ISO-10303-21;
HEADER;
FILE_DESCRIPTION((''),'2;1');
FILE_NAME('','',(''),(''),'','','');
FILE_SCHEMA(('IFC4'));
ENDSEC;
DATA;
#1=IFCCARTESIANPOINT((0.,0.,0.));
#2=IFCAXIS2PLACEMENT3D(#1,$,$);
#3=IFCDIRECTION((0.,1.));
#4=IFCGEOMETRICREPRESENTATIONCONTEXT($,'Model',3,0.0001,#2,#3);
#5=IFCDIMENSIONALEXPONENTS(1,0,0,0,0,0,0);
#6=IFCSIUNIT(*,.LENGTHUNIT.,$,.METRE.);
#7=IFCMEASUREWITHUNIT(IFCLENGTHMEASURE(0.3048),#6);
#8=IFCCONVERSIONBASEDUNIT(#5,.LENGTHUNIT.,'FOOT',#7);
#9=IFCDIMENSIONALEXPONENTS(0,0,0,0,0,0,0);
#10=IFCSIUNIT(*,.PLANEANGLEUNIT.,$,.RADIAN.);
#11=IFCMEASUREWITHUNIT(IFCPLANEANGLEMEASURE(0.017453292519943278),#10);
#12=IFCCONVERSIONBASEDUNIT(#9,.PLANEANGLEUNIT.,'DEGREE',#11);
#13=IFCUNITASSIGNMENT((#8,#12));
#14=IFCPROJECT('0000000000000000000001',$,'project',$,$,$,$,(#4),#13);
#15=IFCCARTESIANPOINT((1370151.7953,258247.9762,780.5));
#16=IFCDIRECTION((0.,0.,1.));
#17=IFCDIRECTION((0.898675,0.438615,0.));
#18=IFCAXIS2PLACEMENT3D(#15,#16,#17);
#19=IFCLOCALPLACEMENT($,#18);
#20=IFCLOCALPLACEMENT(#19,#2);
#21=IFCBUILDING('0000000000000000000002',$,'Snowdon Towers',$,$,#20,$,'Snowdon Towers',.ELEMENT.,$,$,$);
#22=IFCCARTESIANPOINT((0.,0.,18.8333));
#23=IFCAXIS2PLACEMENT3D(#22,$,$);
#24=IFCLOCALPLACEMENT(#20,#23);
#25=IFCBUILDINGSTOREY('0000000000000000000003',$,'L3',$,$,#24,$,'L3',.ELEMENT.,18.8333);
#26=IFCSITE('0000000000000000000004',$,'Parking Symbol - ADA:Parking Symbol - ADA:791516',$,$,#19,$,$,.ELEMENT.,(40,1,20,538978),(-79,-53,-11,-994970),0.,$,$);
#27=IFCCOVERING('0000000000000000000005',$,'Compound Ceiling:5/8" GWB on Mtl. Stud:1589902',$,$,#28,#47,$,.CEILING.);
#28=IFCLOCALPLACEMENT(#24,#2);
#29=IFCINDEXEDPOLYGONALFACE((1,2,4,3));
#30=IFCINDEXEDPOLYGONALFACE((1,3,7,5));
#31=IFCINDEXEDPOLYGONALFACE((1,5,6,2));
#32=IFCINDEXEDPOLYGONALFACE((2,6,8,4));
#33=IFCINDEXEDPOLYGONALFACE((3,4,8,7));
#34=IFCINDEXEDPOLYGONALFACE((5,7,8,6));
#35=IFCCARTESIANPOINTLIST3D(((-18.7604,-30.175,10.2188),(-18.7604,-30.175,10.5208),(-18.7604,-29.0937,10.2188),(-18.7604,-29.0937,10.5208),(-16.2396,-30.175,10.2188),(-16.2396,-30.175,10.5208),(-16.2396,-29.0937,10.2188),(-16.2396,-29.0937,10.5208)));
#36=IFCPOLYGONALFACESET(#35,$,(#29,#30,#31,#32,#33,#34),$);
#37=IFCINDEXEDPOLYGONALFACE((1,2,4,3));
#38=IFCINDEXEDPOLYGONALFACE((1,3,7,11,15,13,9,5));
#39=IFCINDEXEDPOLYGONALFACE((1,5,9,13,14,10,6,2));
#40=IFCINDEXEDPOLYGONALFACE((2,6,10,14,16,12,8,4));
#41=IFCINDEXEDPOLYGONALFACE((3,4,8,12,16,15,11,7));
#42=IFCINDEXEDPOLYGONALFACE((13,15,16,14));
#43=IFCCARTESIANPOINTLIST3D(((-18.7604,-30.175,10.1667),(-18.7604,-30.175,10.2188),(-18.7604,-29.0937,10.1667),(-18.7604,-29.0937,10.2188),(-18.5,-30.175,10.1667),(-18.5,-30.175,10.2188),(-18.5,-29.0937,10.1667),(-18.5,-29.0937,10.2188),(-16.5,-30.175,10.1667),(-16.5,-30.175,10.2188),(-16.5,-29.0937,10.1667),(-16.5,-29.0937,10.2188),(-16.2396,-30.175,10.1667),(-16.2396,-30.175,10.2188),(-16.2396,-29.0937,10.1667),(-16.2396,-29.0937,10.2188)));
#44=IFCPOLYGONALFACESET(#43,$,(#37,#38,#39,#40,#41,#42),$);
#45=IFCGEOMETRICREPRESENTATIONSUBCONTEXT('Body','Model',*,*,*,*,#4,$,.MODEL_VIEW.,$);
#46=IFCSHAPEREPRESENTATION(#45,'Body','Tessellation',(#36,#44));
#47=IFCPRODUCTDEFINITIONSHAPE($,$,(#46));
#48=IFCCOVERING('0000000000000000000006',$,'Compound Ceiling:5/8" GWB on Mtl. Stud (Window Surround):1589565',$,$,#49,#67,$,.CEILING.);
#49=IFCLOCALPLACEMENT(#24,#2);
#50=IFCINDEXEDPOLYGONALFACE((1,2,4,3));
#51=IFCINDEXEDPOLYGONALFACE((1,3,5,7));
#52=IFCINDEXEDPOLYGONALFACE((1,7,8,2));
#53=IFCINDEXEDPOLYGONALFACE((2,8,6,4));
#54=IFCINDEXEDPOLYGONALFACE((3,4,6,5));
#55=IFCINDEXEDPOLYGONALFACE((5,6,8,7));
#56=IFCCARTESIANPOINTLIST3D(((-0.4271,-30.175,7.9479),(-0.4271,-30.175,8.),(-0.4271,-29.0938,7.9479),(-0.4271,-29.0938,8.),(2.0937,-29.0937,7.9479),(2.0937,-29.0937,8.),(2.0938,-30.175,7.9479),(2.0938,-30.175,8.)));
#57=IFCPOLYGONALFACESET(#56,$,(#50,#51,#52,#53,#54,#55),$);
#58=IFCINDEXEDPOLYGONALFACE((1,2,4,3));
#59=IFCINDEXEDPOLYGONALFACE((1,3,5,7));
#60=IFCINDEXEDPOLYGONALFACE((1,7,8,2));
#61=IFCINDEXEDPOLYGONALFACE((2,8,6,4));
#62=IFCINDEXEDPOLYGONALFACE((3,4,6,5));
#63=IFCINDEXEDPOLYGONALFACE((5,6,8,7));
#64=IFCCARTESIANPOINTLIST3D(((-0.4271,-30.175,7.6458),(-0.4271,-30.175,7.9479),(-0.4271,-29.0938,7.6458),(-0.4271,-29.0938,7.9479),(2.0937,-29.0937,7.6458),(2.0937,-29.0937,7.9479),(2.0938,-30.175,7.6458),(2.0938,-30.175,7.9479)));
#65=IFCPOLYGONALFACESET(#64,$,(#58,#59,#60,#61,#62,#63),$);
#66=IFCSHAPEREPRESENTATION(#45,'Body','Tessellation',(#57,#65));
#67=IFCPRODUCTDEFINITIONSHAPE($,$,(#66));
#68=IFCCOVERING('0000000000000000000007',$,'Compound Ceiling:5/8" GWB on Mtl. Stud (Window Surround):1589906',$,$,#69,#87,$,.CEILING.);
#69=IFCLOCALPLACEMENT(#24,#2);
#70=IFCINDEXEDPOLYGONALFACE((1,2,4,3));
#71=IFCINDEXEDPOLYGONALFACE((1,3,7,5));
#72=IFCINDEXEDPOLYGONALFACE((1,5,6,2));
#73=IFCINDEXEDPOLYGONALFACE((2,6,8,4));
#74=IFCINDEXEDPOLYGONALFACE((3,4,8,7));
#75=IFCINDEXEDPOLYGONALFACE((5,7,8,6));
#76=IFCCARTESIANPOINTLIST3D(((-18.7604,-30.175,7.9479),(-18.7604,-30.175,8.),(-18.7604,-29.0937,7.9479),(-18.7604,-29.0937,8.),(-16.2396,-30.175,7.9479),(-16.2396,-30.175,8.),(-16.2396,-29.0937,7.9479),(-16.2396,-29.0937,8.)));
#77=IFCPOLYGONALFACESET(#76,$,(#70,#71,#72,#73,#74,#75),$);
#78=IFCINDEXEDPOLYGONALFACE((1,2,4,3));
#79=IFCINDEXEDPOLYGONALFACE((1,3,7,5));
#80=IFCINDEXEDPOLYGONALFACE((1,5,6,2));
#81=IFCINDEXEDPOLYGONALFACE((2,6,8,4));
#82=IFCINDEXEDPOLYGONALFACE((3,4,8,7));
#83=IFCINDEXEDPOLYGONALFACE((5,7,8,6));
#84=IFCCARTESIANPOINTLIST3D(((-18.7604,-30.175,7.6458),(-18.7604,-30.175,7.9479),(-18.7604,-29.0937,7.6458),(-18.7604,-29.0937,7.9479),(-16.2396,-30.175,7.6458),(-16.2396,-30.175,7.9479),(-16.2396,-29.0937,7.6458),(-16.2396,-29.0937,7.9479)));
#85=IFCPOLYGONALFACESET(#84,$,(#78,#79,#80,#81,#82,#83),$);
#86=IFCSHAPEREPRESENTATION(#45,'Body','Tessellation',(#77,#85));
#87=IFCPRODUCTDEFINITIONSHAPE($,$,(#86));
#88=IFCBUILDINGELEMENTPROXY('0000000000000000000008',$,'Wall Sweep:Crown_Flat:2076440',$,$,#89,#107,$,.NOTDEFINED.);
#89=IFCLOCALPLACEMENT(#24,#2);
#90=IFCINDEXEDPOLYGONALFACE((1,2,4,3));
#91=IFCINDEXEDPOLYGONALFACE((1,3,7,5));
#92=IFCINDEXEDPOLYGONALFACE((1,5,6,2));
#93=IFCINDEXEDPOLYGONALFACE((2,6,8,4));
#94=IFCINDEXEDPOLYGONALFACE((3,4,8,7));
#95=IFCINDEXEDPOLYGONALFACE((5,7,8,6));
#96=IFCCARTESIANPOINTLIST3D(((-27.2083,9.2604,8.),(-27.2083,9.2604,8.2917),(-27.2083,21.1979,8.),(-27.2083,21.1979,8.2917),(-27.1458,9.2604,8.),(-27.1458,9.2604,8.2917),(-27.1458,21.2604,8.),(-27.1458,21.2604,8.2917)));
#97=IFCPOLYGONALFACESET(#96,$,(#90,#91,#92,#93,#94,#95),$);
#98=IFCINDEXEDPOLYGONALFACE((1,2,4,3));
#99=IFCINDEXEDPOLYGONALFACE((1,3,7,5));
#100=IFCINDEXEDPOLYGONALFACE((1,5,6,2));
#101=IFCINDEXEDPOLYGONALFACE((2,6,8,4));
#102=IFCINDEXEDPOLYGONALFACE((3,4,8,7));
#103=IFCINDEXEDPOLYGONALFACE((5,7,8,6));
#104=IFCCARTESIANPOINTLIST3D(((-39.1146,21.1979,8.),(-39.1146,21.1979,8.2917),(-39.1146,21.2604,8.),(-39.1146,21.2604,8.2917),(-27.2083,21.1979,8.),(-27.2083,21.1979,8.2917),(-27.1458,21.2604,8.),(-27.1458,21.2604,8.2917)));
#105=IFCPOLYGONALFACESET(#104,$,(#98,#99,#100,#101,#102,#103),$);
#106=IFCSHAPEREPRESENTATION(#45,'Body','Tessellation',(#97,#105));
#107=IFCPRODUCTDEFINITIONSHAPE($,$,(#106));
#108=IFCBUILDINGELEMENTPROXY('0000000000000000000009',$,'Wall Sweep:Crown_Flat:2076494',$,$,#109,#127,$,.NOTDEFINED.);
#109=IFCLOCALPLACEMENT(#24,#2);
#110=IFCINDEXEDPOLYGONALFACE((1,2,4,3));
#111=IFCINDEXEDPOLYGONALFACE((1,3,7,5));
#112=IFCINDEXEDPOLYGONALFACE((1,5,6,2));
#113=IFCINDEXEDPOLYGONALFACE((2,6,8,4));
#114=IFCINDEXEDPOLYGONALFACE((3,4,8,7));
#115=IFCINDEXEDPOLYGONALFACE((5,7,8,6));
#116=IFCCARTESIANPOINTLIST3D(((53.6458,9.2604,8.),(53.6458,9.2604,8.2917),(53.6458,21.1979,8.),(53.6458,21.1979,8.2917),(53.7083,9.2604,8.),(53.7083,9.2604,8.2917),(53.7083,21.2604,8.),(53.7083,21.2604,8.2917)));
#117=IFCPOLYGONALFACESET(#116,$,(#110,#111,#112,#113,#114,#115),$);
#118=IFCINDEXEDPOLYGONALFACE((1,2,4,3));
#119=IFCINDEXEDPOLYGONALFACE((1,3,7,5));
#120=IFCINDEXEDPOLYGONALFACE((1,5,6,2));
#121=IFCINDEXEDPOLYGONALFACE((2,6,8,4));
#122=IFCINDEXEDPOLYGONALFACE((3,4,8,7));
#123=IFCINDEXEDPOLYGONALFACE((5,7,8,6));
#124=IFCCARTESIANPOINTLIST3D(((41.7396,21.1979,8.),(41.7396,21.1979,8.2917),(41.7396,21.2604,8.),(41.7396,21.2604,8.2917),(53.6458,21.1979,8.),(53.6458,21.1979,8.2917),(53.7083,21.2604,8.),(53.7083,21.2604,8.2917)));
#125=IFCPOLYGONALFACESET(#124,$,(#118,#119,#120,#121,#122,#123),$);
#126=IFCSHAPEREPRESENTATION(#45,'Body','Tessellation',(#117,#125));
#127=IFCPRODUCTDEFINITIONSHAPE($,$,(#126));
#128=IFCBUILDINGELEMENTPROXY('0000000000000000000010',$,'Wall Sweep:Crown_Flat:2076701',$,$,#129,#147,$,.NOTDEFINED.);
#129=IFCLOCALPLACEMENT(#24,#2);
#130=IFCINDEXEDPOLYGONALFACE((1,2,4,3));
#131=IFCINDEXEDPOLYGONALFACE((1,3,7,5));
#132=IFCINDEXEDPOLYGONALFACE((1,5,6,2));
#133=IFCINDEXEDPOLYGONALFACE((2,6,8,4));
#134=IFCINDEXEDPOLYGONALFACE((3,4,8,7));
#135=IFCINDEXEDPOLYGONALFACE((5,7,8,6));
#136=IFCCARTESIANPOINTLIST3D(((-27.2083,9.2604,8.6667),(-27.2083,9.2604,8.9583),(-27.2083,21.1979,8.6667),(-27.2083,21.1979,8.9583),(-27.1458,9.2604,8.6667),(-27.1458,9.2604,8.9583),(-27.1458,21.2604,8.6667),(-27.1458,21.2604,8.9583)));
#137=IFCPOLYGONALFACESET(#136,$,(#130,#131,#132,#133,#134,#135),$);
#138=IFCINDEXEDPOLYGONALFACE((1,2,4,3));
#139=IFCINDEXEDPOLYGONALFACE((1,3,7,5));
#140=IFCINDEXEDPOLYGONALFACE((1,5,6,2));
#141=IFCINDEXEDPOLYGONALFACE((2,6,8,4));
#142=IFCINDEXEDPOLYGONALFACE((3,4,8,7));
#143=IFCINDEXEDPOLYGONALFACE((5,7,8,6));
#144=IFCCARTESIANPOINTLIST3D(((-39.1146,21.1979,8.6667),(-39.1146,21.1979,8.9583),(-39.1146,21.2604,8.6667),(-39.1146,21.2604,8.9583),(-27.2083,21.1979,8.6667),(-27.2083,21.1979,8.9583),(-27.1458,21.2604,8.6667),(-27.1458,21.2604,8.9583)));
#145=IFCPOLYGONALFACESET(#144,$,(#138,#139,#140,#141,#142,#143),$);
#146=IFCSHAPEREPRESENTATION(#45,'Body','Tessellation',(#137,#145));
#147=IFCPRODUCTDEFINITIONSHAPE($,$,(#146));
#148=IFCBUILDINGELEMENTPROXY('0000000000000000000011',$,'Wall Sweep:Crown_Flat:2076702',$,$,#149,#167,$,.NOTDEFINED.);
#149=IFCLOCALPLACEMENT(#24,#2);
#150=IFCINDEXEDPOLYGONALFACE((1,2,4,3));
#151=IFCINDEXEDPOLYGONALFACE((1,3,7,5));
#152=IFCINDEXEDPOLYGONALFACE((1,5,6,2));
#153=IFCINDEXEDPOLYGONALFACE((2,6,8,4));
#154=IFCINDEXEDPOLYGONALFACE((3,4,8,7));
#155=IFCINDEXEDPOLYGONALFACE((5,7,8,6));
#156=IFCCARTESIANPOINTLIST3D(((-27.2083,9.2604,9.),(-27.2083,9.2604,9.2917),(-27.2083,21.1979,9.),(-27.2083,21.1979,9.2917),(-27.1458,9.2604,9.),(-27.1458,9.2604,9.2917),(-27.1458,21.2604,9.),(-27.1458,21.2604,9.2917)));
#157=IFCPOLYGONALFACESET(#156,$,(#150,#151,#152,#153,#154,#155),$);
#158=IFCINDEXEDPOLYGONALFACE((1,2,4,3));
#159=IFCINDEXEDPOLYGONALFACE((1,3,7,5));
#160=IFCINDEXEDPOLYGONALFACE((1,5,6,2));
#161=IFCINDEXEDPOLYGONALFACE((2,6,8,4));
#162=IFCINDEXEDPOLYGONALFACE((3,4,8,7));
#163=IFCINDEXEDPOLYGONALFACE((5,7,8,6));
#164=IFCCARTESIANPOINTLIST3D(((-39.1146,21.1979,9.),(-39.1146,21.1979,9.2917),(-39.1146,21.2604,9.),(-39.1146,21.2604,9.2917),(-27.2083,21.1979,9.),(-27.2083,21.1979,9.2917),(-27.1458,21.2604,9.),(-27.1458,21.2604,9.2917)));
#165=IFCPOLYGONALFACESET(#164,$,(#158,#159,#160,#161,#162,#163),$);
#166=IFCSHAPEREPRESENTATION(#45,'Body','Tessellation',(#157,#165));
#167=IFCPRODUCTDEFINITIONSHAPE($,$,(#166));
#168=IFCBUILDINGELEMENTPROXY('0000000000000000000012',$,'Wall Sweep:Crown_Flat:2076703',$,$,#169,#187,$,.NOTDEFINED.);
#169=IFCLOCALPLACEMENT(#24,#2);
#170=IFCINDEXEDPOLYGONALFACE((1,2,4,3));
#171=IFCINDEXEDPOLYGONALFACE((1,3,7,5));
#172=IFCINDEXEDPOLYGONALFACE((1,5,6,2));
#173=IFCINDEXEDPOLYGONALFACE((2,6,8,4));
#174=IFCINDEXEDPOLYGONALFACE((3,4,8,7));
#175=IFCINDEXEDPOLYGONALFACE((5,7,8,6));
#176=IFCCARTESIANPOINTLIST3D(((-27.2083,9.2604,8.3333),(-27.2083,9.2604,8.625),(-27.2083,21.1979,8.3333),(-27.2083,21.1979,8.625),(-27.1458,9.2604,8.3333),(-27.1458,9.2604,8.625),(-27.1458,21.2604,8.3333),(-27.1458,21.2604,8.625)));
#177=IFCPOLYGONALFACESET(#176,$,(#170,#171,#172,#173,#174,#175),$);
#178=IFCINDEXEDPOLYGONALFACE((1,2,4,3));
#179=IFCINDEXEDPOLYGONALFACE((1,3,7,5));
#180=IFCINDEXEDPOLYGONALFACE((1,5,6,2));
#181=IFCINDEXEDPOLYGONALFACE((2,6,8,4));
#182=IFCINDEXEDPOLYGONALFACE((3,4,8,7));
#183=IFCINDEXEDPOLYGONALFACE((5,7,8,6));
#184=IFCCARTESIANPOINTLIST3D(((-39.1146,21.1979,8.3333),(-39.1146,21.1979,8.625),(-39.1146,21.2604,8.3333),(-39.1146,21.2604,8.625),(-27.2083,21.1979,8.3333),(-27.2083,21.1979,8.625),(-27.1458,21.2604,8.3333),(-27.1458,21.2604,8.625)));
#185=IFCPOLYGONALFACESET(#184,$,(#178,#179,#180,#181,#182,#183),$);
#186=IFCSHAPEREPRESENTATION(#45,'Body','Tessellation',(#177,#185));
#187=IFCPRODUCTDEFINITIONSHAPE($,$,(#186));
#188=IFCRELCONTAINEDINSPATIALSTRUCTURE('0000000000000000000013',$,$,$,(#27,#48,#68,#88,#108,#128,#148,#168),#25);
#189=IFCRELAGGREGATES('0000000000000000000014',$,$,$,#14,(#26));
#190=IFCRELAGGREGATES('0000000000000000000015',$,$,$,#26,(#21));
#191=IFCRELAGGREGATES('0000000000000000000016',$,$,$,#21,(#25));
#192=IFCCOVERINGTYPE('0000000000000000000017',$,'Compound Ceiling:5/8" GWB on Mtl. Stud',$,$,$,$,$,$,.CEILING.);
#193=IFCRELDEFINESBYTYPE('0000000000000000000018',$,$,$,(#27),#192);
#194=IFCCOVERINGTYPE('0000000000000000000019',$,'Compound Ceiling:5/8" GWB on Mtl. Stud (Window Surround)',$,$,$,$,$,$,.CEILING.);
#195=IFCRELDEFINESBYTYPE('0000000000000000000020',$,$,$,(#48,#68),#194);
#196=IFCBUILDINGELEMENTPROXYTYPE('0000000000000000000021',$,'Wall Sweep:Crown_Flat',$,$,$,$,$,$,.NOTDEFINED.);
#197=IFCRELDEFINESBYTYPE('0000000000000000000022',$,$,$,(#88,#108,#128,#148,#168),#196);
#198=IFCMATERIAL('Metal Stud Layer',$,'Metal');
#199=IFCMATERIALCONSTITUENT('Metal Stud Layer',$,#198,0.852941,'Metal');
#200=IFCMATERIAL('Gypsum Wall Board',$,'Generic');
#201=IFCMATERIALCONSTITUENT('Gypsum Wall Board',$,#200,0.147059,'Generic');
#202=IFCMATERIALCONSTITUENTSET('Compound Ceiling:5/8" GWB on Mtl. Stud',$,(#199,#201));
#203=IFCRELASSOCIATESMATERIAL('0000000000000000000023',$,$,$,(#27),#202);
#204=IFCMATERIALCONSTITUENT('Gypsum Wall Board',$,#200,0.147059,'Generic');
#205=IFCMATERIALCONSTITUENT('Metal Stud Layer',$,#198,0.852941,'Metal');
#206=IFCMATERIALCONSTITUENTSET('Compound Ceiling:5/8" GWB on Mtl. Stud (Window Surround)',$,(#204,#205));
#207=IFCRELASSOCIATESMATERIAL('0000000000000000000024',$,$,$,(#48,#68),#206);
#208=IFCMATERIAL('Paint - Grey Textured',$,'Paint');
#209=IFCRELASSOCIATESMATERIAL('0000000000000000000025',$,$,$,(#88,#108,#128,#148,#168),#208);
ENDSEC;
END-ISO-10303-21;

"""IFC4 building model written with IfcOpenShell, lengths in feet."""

from ifc_helpers import new_model, entity, si_unit, converted_unit, direction, frame, origin, place, context, subcontext, project, spatial, indexed_curve, outline, extrude, material, constituent, constituent_set, type_object, element, save


model = new_model("IFC4")

# Units and contexts
model_context = context("Model", 3, precision=0.0001, world=origin(), true_north=direction((0.0, 1.0)))
body_context = subcontext(model_context, "Body", "Model", "MODEL_VIEW")
ifc_project = project(units=[converted_unit("LENGTHUNIT", "FOOT", entity("IfcLengthMeasure", 0.3048), si_unit("LENGTHUNIT", "METRE"), dimensions=[1, 0, 0, 0, 0, 0, 0]), converted_unit("PLANEANGLEUNIT", "DEGREE", entity("IfcPlaneAngleMeasure", 0.017453292519943278), si_unit("PLANEANGLEUNIT", "RADIAN"), dimensions=[0, 0, 0, 0, 0, 0, 0])], contexts=[model_context])

# Site, building, storey
site_placement = place(None, frame((1370151.7953, 258247.9762, 780.5), z_axis=(0.0, 0.0, 1.0), x_axis=(0.898675, 0.438615, 0.0)))
site = spatial("IfcSite", under=ifc_project, at=site_placement, Name="Parking Symbol - ADA:Parking Symbol - ADA:791516", CompositionType="ELEMENT", RefLatitude=(40, 1, 20, 538978), RefLongitude=(-79, -53, -11, -994970), RefElevation=0.0)
building_placement = place(site_placement, origin())
building = spatial("IfcBuilding", under=site, at=building_placement, Name="Snowdon Towers", LongName="Snowdon Towers", CompositionType="ELEMENT")
storey_placement = place(building_placement, frame((0.0, 0.0, 18.8333)))
storey = spatial("IfcBuildingStorey", under=building, at=storey_placement, Name="L3", LongName="L3", CompositionType="ELEMENT", Elevation=18.8333)

# Shared definitions
ifc_material_1 = material(Name="Gypsum Wall Board", Category="Generic")

# Shared definitions
ifc_material_2 = material(Name="Metal Stud Layer", Category="Metal")

# Covering
ifc_constituent_1 = constituent(ifc_material_2, Name="Metal Stud Layer", Category="Metal", fraction=0.852941)
ifc_constituent_2 = constituent(ifc_material_1, Name="Gypsum Wall Board", Category="Generic", fraction=0.147059)
ifc_constituent_set_1 = constituent_set(constituents=[ifc_constituent_1, ifc_constituent_2], Name="Compound Ceiling:5/8\" GWB on Mtl. Stud")
covering_type_1 = type_object("IfcCoveringType", Name="Compound Ceiling:5/8\" GWB on Mtl. Stud", PredefinedType="CEILING")
covering_1_placement = place(storey_placement, origin())
element("IfcCovering", 1, at=covering_1_placement, inside=storey, type_object=covering_type_1, material=ifc_constituent_set_1, Name="Compound Ceiling:5/8\" GWB on Mtl. Stud:1589902", PredefinedType="CEILING", context=body_context, shape_type="SweptSolid", body=[
    extrude(outline(indexed_curve([(-0.5406, -1.2604), (0.5406, -1.2604), (0.5406, 1.2604), (-0.5406, 1.2604), (-0.5406, -1.2604)], self_intersect=False)), frame((-17.5, -29.6344, 10.2188), z_axis=(0.0, 0.0, 1.0), x_axis=(0.0, 1.0, 0.0)), (0.0, 0.0, 1.0), 0.3021),
    extrude(outline(indexed_curve([(-0.5406, -1.2604), (0.5406, -1.2604), (0.5406, -1.0), (0.5406, 1.0), (0.5406, 1.2604), (-0.5406, 1.2604), (-0.5406, 1.0), (-0.5406, -1.0), (-0.5406, -1.2604)], self_intersect=False)), frame((-17.5, -29.6344, 10.1667), z_axis=(0.0, 0.0, 1.0), x_axis=(0.0, -1.0, 0.0)), (0.0, 0.0, 1.0), 0.0521),
])

# Coverings
ifc_constituent_3 = constituent(ifc_material_1, Name="Gypsum Wall Board", Category="Generic", fraction=0.147059)
ifc_constituent_4 = constituent(ifc_material_2, Name="Metal Stud Layer", Category="Metal", fraction=0.852941)
ifc_constituent_set_2 = constituent_set(constituents=[ifc_constituent_3, ifc_constituent_4], Name="Compound Ceiling:5/8\" GWB on Mtl. Stud (Window Surround)")
covering_type_2 = type_object("IfcCoveringType", Name="Compound Ceiling:5/8\" GWB on Mtl. Stud (Window Surround)", PredefinedType="CEILING")
covering_2_placement = place(storey_placement, origin())
element("IfcCovering", 2, at=covering_2_placement, inside=storey, type_object=covering_type_2, material=ifc_constituent_set_2, Name="Compound Ceiling:5/8\" GWB on Mtl. Stud (Window Surround):1589565", PredefinedType="CEILING", context=body_context, shape_type="SweptSolid", body=[
    extrude(outline(indexed_curve([(-0.5406, -1.2604), (0.5406, -1.2604), (0.5406, 1.2604), (-0.5406, 1.2604), (-0.5406, -1.2604)], self_intersect=False)), frame((0.8333, -29.6344, 7.9479), z_axis=(0.0, 0.0, 1.0), x_axis=(0.0, 1.0, 0.0)), (0.0, 0.0, 1.0), 0.0521),
    extrude(outline(indexed_curve([(-1.2604, -0.5406), (1.2604, -0.5406), (1.2604, 0.5406), (-1.2604, 0.5406), (-1.2604, -0.5406)], self_intersect=False)), frame((0.8333, -29.6344, 7.6458), z_axis=(0.0, 0.0, 1.0), x_axis=(-1.0, 0.0, 0.0)), (0.0, 0.0, 1.0), 0.3021),
])
covering_3_placement = place(storey_placement, origin())
element("IfcCovering", 3, at=covering_3_placement, inside=storey, type_object=covering_type_2, material=ifc_constituent_set_2, Name="Compound Ceiling:5/8\" GWB on Mtl. Stud (Window Surround):1589906", PredefinedType="CEILING", context=body_context, shape_type="SweptSolid", body=[
    extrude(outline(indexed_curve([(-0.5406, -1.2604), (0.5406, -1.2604), (0.5406, 1.2604), (-0.5406, 1.2604), (-0.5406, -1.2604)], self_intersect=False)), frame((-17.5, -29.6344, 7.9479), z_axis=(0.0, 0.0, 1.0), x_axis=(0.0, 1.0, 0.0)), (0.0, 0.0, 1.0), 0.0521),
    extrude(outline(indexed_curve([(-1.2604, -0.5406), (1.2604, -0.5406), (1.2604, 0.5406), (-1.2604, 0.5406), (-1.2604, -0.5406)], self_intersect=False)), frame((-17.5, -29.6344, 7.6458), z_axis=(0.0, 0.0, 1.0), x_axis=(-1.0, 0.0, 0.0)), (0.0, 0.0, 1.0), 0.3021),
])

# Building element proxies
ifc_material_3 = material(Name="Paint - Grey Textured", Category="Paint")
building_element_proxy_type = type_object("IfcBuildingElementProxyType", Name="Wall Sweep:Crown_Flat", PredefinedType="NOTDEFINED")
proxy_1_placement = place(storey_placement, origin())
element("IfcBuildingElementProxy", 4, at=proxy_1_placement, inside=storey, type_object=building_element_proxy_type, material=ifc_material_3, Name="Wall Sweep:Crown_Flat:2076440", PredefinedType="NOTDEFINED", context=body_context, shape_type="SweptSolid", body=[
    extrude(outline(indexed_curve([(-5.9531, -0.0312), (5.9844, -0.0312), (5.9844, 0.0312), (-6.0156, 0.0312), (-5.9531, -0.0312)], self_intersect=False)), frame((-27.1771, 15.2448, 8.0), z_axis=(0.0, 0.0, 1.0), x_axis=(0.0, -1.0, 0.0)), (0.0, 0.0, 1.0), 0.2917),
    extrude(outline(indexed_curve([(-5.9688, -0.0312), (5.9375, -0.0312), (6.0, 0.0313), (-5.9688, 0.0313), (-5.9688, -0.0312)], self_intersect=False)), frame((-33.1458, 21.2292, 8.0)), (0.0, 0.0, 1.0), 0.2917),
])
proxy_2_placement = place(storey_placement, origin())
element("IfcBuildingElementProxy", 5, at=proxy_2_placement, inside=storey, type_object=building_element_proxy_type, material=ifc_material_3, Name="Wall Sweep:Crown_Flat:2076494", PredefinedType="NOTDEFINED", context=body_context, shape_type="SweptSolid", body=[
    extrude(outline(indexed_curve([(-5.9531, -0.0312), (5.9844, -0.0312), (5.9844, 0.0312), (-6.0156, 0.0312), (-5.9531, -0.0312)], self_intersect=False)), frame((53.6771, 15.2448, 8.0), z_axis=(0.0, 0.0, 1.0), x_axis=(0.0, -1.0, 0.0)), (0.0, 0.0, 1.0), 0.2917),
    extrude(outline(indexed_curve([(-5.9688, -0.0312), (5.9375, -0.0312), (6.0, 0.0313), (-5.9688, 0.0313), (-5.9688, -0.0312)], self_intersect=False)), frame((47.7083, 21.2292, 8.0)), (0.0, 0.0, 1.0), 0.2917),
])
proxy_3_placement = place(storey_placement, origin())
element("IfcBuildingElementProxy", 6, at=proxy_3_placement, inside=storey, type_object=building_element_proxy_type, material=ifc_material_3, Name="Wall Sweep:Crown_Flat:2076701", PredefinedType="NOTDEFINED", context=body_context, shape_type="SweptSolid", body=[
    extrude(outline(indexed_curve([(-5.9531, -0.0312), (5.9844, -0.0312), (5.9844, 0.0312), (-6.0156, 0.0312), (-5.9531, -0.0312)], self_intersect=False)), frame((-27.1771, 15.2448, 8.6667), z_axis=(0.0, 0.0, 1.0), x_axis=(0.0, -1.0, 0.0)), (0.0, 0.0, 1.0), 0.2917),
    extrude(outline(indexed_curve([(-5.9688, -0.0312), (5.9375, -0.0312), (6.0, 0.0313), (-5.9688, 0.0313), (-5.9688, -0.0312)], self_intersect=False)), frame((-33.1458, 21.2292, 8.6667)), (0.0, 0.0, 1.0), 0.2917),
])
proxy_4_placement = place(storey_placement, origin())
element("IfcBuildingElementProxy", 7, at=proxy_4_placement, inside=storey, type_object=building_element_proxy_type, material=ifc_material_3, Name="Wall Sweep:Crown_Flat:2076702", PredefinedType="NOTDEFINED", context=body_context, shape_type="SweptSolid", body=[
    extrude(outline(indexed_curve([(-5.9531, -0.0312), (5.9844, -0.0312), (5.9844, 0.0312), (-6.0156, 0.0312), (-5.9531, -0.0312)], self_intersect=False)), frame((-27.1771, 15.2448, 9.0), z_axis=(0.0, 0.0, 1.0), x_axis=(0.0, -1.0, 0.0)), (0.0, 0.0, 1.0), 0.2917),
    extrude(outline(indexed_curve([(-5.9688, -0.0312), (5.9375, -0.0312), (6.0, 0.0313), (-5.9688, 0.0313), (-5.9688, -0.0312)], self_intersect=False)), frame((-33.1458, 21.2292, 9.0)), (0.0, 0.0, 1.0), 0.2917),
])
proxy_5_placement = place(storey_placement, origin())
element("IfcBuildingElementProxy", 8, at=proxy_5_placement, inside=storey, type_object=building_element_proxy_type, material=ifc_material_3, Name="Wall Sweep:Crown_Flat:2076703", PredefinedType="NOTDEFINED", context=body_context, shape_type="SweptSolid", body=[
    extrude(outline(indexed_curve([(-5.9531, -0.0312), (5.9844, -0.0312), (5.9844, 0.0312), (-6.0156, 0.0312), (-5.9531, -0.0312)], self_intersect=False)), frame((-27.1771, 15.2448, 8.3333), z_axis=(0.0, 0.0, 1.0), x_axis=(0.0, -1.0, 0.0)), (0.0, 0.0, 1.0), 0.2917),
    extrude(outline(indexed_curve([(-5.9688, -0.0312), (5.9375, -0.0312), (6.0, 0.0313), (-5.9688, 0.0313), (-5.9688, -0.0312)], self_intersect=False)), frame((-33.1458, 21.2292, 8.3333)), (0.0, 0.0, 1.0), 0.2917),
])

save(model, "model.ifc")
